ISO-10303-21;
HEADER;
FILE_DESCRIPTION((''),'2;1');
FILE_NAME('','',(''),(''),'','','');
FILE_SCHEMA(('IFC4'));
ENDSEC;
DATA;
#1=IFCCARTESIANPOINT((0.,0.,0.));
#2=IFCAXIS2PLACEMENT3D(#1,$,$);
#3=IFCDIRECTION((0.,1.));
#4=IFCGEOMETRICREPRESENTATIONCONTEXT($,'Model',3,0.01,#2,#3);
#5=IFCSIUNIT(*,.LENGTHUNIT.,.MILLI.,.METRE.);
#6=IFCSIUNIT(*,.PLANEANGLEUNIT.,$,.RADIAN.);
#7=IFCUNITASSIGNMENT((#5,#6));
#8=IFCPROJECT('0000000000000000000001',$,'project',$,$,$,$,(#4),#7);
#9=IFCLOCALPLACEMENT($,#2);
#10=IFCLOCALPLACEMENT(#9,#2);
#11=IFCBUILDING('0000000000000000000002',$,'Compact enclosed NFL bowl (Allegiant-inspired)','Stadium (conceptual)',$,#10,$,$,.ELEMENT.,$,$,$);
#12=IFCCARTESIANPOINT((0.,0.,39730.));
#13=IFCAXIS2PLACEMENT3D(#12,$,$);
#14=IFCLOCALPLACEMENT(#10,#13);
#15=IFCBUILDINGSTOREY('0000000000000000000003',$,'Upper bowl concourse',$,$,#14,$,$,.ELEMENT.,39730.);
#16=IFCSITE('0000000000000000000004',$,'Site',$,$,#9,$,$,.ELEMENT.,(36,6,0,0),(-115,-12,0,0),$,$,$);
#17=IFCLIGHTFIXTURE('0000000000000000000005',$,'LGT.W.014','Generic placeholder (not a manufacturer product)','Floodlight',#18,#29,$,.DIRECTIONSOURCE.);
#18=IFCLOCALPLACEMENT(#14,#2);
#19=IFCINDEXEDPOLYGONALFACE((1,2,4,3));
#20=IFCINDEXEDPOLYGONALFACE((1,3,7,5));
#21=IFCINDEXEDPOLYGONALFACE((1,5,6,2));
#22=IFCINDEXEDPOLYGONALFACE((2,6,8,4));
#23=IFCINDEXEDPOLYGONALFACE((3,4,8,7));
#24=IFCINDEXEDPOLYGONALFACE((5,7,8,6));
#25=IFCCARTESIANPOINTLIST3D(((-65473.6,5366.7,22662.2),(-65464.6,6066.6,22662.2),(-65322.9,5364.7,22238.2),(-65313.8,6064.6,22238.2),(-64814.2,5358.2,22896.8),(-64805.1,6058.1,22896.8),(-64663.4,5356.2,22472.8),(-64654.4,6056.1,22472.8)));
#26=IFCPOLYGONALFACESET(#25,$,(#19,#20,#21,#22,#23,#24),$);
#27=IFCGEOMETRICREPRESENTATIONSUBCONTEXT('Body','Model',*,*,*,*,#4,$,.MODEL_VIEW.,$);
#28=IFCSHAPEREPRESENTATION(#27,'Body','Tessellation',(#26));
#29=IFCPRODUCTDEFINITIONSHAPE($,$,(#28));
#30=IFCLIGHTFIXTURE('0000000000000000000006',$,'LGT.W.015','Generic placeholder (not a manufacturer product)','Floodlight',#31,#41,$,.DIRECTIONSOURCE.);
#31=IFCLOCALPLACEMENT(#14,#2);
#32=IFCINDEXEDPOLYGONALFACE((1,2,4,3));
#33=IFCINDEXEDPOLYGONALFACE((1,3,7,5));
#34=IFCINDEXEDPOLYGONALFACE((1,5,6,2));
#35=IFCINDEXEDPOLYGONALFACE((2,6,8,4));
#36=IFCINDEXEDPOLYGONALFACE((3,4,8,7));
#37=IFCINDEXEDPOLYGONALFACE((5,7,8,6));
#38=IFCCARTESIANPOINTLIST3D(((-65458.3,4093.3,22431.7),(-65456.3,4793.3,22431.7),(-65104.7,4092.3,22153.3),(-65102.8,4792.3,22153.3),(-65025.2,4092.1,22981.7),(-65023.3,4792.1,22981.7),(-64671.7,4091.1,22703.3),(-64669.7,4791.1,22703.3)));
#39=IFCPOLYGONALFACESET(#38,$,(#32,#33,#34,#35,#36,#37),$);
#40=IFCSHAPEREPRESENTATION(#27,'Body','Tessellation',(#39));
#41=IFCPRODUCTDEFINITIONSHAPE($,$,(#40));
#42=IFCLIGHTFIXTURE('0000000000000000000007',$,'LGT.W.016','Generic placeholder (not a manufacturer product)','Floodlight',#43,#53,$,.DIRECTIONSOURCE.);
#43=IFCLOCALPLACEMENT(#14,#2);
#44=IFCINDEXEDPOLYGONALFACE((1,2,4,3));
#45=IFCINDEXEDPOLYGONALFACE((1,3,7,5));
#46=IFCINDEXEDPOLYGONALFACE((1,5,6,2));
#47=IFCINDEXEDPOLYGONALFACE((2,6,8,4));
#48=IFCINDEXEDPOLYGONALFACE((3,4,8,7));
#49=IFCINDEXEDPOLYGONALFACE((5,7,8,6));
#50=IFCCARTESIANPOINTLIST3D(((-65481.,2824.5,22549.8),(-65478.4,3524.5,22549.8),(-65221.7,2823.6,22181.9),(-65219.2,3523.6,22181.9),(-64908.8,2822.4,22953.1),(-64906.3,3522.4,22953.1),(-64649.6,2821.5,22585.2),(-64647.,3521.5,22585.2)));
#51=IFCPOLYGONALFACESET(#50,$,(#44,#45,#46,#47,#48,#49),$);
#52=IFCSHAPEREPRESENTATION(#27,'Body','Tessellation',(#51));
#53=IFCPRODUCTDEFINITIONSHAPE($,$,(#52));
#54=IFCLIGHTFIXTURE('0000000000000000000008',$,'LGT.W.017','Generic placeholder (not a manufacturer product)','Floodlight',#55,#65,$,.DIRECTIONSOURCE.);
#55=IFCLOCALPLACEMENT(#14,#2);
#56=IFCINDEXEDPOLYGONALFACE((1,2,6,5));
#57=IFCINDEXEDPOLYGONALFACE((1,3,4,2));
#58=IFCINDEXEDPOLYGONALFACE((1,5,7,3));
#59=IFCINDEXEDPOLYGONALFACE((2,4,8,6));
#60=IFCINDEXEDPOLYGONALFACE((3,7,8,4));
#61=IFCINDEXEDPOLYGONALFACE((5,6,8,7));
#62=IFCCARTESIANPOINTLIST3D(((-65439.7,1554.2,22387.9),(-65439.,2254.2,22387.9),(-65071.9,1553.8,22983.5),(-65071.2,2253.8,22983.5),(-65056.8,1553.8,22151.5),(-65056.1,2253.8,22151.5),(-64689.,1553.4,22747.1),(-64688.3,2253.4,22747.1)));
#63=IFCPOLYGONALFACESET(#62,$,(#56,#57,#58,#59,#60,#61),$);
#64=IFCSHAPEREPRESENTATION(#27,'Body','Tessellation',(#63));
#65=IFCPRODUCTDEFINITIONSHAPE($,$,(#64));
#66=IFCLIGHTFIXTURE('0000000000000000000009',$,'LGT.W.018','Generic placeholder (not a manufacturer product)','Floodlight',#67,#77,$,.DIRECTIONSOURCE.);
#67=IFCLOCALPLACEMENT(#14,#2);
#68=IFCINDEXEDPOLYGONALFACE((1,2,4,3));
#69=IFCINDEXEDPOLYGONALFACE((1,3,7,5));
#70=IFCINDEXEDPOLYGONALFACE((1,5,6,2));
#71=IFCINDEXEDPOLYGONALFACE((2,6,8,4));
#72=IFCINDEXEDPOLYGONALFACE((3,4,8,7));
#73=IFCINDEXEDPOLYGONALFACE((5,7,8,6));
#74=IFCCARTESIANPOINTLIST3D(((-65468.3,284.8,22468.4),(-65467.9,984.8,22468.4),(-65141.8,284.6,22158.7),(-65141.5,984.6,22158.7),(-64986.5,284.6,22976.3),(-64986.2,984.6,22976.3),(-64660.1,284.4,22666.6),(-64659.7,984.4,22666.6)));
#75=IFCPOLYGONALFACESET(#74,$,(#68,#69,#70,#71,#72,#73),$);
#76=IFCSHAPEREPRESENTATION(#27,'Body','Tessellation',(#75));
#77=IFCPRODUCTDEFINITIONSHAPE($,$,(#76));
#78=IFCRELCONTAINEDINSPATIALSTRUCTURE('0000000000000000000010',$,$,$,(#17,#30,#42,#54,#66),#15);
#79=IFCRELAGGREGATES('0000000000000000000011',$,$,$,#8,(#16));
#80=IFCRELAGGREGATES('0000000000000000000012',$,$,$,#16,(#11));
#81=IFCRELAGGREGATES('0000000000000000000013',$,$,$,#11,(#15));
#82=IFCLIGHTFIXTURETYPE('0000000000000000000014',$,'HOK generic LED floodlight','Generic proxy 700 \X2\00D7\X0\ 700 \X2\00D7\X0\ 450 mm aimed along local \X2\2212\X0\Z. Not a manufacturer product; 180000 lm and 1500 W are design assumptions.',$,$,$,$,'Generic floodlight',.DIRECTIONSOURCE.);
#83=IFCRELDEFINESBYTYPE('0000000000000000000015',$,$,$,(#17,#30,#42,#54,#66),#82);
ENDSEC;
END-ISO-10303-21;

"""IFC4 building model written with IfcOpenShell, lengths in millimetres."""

from ifc_helpers import new_model, si_unit, direction, frame, origin, place, context, subcontext, project, spatial, rectangle, extrude, source, transform, mapped, type_object, type_shapes, element, save


model = new_model("IFC4")

# Units and contexts
model_context = context("Model", 3, precision=0.01, world=origin(), true_north=direction((0.0, 1.0)))
body_context = subcontext(model_context, "Body", "Model", "MODEL_VIEW")
ifc_project = project(units=[si_unit("LENGTHUNIT", "METRE", prefix="MILLI"), si_unit("PLANEANGLEUNIT", "RADIAN")], contexts=[model_context])

# Site, building, storey
site_placement = place(None, origin())
site = spatial("IfcSite", under=ifc_project, at=site_placement, Name="Site", CompositionType="ELEMENT", RefLatitude=(36, 6, 0, 0), RefLongitude=(-115, -12, 0, 0))
building_placement = place(site_placement, origin())
building = spatial("IfcBuilding", under=site, at=building_placement, Name="Compact enclosed NFL bowl (Allegiant-inspired)", Description="Stadium (conceptual)", CompositionType="ELEMENT")
storey_placement = place(building_placement, frame((0.0, 0.0, 39730.0)))
storey = spatial("IfcBuildingStorey", under=building, at=storey_placement, Name="Upper bowl concourse", CompositionType="ELEMENT", Elevation=39730.0)

# Light fixtures
light_fixture_type = type_object("IfcLightFixtureType", Name="HOK generic LED floodlight", Description="Generic proxy 700 × 700 × 450 mm aimed along local −Z. Not a manufacturer product; 180000 lm and 1500 W are design assumptions.", ElementType="Generic floodlight", PredefinedType="DIRECTIONSOURCE")
shared_shape = source(origin(), body_context, "Body", "SweptSolid", [
    extrude(rectangle(XDim=700.0, YDim=700.0), frame((0.0, 0.0, -225.0)), (0.0, 0.0, 1.0), 450.0),
])
type_shapes(light_fixture_type, [shared_shape])
for number, where, z_axis, x_axis, name in (
    (1, (-65064.0, 5711.4, 22567.5), (-0.335041, 0.004319, 0.942194), (-0.01289, -0.999917, 0.0), "LGT.W.014"),
    (2, (-65064.0, 4442.2, 22567.5), (-0.785672, 0.002206, 0.618639), (-0.002807, -0.999996, 0.0), "LGT.W.015"),
    (3, (-65064.0, 3173.0, 22567.5), (-0.576129, 0.002082, 0.817356), (-0.003613, -0.999993, 0.0), "LGT.W.016"),
    (4, (-65064.0, 1903.8, 22567.5), (-0.850831, 0.000803, 0.52544), (-0.000944, -1.0, 0.0), "LGT.W.017"),
    (5, (-65064.0, 634.6, 22567.5), (-0.725492, 0.000351, 0.688231), (-0.000483, -1.0, 0.0), "LGT.W.018"),
):
    element("IfcLightFixture", number, at=place(storey_placement, frame(where, z_axis=z_axis, x_axis=x_axis)), inside=storey, type_object=light_fixture_type, Name=name, Description="Generic placeholder (not a manufacturer product)", ObjectType="Floodlight", PredefinedType="DIRECTIONSOURCE", context=body_context, shape_type="MappedRepresentation", body=[
        mapped(shared_shape, transform((0.0, 0.0, 0.0))),
    ])

save(model, "model.ifc")
